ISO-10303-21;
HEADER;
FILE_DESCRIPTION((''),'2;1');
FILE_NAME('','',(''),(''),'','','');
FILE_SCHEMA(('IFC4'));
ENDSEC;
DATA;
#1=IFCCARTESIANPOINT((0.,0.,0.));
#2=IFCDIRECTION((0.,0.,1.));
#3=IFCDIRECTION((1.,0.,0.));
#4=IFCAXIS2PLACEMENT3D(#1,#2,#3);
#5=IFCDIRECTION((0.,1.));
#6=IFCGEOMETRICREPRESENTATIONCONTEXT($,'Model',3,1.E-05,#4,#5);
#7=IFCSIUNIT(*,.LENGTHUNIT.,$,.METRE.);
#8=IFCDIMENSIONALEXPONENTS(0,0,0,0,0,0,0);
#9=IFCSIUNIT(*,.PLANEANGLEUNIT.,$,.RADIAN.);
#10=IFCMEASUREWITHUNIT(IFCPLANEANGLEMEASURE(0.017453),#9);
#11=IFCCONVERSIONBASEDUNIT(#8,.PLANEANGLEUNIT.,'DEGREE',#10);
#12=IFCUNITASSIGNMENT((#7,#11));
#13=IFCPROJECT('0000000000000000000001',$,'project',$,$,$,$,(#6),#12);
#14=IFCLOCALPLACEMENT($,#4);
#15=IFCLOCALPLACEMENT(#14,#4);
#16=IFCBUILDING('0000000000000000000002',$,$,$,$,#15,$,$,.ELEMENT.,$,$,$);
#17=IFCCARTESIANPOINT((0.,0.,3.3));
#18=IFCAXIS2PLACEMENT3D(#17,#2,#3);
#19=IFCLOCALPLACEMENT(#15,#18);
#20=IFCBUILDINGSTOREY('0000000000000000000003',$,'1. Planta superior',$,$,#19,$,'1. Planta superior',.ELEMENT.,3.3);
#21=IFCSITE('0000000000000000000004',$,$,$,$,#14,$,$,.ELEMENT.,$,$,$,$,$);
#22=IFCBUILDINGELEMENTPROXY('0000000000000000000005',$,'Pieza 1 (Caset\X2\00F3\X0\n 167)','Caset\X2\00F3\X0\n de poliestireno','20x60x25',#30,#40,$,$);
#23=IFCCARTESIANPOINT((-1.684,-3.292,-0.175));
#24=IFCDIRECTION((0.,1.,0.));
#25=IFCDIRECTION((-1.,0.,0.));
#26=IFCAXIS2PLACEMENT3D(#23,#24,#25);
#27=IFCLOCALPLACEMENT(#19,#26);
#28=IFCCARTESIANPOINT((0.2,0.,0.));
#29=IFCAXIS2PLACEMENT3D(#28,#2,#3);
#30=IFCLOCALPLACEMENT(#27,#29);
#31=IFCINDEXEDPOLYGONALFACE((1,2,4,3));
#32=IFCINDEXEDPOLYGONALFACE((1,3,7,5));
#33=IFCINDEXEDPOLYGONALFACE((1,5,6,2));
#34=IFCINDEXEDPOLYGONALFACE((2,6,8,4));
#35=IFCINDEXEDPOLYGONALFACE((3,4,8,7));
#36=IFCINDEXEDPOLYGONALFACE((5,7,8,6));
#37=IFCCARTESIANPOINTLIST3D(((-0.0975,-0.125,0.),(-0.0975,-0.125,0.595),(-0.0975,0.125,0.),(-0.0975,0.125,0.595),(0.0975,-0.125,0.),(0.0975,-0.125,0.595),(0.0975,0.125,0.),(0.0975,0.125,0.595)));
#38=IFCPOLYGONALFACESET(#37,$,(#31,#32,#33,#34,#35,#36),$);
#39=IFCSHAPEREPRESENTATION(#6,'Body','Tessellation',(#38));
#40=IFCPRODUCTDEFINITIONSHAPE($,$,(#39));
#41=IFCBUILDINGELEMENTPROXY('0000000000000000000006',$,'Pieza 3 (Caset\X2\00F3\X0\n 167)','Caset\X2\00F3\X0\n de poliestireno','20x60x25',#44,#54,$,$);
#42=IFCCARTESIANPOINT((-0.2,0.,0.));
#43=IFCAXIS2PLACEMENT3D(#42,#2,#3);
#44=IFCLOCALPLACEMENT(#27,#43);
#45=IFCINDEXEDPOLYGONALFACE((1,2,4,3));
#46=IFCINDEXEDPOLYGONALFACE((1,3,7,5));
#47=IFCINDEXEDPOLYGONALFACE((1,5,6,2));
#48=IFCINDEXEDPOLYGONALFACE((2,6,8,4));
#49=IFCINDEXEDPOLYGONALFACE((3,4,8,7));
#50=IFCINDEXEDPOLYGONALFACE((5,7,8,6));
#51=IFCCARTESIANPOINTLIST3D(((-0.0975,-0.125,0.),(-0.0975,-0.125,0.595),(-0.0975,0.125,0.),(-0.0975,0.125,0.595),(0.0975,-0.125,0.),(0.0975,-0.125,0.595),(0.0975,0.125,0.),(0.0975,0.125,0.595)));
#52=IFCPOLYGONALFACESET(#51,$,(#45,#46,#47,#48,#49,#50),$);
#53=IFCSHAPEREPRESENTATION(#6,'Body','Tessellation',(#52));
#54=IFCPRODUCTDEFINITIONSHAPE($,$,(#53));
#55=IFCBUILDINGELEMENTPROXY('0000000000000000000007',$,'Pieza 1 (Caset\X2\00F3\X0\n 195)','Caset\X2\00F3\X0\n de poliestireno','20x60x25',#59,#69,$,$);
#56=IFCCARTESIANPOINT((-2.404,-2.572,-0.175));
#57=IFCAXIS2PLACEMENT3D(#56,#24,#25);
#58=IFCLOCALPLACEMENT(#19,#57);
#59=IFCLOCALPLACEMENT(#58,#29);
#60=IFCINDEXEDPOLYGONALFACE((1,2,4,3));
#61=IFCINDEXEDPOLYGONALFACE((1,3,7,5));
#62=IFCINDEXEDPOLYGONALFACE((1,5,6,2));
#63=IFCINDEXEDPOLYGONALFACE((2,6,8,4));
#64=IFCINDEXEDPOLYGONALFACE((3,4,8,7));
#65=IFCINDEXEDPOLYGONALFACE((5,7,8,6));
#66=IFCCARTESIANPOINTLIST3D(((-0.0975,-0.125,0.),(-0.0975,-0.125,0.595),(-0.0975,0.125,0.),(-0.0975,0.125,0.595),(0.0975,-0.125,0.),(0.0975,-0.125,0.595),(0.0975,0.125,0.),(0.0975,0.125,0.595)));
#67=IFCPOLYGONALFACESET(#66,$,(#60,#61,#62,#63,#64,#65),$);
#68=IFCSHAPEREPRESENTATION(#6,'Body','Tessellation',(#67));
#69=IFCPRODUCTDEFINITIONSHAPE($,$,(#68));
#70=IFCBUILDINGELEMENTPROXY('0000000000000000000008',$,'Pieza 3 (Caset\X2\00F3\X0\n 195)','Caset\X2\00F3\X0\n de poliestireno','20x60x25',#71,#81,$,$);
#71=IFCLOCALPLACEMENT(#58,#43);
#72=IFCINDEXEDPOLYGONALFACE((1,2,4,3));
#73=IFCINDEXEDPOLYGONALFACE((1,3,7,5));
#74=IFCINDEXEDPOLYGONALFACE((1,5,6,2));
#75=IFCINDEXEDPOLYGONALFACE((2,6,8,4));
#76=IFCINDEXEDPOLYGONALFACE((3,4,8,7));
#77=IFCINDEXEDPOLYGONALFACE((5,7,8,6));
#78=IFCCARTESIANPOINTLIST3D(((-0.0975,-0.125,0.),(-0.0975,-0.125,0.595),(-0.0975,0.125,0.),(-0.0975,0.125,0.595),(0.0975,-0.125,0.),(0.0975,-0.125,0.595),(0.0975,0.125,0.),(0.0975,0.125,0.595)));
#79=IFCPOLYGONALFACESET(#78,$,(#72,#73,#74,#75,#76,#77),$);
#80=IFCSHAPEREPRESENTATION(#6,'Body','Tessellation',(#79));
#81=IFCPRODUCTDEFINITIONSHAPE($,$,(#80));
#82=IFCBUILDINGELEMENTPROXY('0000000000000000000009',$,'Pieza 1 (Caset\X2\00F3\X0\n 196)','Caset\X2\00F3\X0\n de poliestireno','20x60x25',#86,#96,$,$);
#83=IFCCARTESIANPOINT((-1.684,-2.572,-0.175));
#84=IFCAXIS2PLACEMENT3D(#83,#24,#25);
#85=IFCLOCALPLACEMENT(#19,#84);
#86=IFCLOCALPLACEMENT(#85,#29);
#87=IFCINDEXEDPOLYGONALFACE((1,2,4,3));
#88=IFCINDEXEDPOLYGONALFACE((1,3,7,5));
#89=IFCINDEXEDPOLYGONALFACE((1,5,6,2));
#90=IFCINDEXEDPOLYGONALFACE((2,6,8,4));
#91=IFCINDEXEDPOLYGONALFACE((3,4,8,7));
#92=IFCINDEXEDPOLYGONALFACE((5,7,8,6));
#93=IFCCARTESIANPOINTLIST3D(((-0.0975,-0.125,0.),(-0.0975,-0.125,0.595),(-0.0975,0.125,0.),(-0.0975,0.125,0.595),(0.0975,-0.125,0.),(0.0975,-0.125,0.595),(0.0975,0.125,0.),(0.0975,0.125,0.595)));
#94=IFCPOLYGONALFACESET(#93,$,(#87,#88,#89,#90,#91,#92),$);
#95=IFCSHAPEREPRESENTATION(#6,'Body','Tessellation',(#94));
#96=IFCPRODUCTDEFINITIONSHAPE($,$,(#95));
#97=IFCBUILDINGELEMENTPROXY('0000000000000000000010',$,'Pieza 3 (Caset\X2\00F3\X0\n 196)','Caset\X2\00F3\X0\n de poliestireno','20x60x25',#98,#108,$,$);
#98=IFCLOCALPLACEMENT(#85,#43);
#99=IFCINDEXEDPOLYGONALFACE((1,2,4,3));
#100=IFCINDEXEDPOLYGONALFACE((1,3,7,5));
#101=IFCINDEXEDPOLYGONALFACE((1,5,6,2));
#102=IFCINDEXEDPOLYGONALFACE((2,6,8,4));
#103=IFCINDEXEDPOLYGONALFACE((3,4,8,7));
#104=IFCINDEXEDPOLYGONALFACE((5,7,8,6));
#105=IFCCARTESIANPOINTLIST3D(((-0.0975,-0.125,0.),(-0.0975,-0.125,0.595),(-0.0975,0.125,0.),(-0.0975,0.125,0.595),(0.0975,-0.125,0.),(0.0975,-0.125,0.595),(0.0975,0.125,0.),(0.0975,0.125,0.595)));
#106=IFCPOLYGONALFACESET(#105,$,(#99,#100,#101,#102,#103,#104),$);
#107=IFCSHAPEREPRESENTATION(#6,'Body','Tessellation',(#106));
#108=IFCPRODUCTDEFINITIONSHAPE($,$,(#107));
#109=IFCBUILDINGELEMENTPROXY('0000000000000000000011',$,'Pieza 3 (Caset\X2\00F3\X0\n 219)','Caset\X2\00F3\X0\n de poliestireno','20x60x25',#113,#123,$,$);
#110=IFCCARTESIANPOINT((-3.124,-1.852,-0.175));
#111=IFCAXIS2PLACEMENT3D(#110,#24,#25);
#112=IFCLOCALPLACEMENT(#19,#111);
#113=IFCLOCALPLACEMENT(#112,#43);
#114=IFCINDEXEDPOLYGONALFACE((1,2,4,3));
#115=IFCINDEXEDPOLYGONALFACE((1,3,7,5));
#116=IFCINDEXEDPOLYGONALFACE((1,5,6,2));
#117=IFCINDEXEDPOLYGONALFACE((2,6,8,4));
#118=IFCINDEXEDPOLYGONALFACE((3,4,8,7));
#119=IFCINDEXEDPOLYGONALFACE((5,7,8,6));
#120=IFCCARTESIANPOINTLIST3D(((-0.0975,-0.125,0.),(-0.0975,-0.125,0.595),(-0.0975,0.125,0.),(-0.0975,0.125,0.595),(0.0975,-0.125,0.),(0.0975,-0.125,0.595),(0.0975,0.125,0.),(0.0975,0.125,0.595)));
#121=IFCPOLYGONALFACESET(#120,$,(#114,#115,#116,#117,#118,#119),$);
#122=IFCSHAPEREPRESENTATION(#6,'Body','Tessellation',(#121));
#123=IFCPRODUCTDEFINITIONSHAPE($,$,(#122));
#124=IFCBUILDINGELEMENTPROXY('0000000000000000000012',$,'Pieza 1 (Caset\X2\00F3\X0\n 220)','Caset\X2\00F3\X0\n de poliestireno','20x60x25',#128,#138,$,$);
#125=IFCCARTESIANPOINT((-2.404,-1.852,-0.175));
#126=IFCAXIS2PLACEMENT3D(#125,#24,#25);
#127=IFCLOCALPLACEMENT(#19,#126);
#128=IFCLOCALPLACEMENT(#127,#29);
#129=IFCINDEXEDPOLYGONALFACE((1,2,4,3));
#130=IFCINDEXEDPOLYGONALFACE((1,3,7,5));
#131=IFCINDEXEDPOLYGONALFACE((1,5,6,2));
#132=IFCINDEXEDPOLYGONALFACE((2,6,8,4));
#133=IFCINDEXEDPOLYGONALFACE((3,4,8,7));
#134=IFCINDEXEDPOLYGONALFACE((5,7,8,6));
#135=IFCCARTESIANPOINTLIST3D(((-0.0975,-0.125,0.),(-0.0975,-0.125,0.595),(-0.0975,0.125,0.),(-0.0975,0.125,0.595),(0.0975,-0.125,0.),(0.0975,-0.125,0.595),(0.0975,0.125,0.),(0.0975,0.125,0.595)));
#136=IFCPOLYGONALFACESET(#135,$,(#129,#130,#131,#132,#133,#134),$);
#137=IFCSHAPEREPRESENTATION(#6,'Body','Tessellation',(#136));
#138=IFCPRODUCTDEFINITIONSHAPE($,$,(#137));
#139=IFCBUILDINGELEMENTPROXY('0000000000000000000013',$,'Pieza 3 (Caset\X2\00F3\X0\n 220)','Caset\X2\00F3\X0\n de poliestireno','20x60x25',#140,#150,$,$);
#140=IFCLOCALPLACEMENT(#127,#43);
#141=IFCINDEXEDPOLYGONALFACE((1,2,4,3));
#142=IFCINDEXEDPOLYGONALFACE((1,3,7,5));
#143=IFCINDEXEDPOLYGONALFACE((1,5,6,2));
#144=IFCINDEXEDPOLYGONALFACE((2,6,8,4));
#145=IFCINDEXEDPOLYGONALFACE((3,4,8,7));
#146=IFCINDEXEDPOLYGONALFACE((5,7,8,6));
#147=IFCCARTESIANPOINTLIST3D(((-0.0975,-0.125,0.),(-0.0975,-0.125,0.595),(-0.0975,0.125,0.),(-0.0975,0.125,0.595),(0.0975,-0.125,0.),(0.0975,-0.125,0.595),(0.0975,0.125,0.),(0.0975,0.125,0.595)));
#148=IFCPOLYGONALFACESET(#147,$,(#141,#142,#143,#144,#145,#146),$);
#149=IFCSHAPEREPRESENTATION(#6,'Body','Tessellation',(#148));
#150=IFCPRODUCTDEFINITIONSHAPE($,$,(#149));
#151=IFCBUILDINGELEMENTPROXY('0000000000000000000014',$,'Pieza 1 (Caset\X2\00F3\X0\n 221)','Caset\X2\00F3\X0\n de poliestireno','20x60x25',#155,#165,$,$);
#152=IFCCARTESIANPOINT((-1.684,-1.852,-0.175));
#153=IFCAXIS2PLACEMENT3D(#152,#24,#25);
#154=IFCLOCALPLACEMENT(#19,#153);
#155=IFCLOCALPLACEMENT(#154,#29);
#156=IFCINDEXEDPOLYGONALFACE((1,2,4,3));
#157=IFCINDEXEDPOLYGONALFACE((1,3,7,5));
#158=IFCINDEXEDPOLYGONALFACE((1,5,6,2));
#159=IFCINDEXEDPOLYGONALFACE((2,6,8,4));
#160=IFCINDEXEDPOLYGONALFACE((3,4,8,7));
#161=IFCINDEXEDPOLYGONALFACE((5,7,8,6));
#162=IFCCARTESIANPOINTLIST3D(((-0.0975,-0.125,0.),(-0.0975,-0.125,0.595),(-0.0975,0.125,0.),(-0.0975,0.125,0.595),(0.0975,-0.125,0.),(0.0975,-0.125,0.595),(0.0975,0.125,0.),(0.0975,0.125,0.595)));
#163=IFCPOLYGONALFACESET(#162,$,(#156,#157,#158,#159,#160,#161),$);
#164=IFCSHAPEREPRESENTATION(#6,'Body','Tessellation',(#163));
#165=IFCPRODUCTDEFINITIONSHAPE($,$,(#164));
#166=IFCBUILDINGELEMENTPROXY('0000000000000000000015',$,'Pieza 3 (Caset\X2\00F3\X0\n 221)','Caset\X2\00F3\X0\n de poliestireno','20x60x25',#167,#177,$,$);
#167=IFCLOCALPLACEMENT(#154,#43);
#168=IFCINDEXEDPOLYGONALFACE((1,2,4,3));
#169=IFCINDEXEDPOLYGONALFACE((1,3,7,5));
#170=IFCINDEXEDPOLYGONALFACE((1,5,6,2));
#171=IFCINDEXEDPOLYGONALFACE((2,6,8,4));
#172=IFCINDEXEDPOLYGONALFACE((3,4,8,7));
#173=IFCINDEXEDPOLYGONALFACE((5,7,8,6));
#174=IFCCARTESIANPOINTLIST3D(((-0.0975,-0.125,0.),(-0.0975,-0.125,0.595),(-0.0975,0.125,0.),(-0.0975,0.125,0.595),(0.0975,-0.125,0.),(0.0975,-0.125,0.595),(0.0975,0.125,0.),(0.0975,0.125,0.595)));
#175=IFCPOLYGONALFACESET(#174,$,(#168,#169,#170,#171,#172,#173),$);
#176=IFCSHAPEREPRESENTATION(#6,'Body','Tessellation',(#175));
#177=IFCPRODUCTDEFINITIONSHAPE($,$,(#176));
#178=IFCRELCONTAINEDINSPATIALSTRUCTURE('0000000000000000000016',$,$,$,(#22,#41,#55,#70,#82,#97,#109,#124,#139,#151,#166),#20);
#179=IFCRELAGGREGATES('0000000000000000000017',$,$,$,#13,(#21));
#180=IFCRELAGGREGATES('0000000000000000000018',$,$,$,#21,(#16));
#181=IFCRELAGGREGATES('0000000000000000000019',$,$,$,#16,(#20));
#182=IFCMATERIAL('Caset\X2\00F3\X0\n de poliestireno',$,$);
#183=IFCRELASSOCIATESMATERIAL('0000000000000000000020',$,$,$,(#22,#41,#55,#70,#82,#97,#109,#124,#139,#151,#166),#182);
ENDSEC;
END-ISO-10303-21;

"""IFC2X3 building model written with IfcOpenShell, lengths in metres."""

from ifc_helpers import new_model, entity, si_unit, converted_unit, direction, frame, origin_with_axes, origin_2d_with_axis, place, context, project, spatial, rectangle, extrude, source, transform, mapped, material, element, save


model = new_model("IFC2X3")

# Units and contexts
model_context = context("Model", 3, precision=1e-05, world=origin_with_axes(), true_north=direction((0.0, 1.0)))
ifc_project = project(units=[si_unit("LENGTHUNIT", "METRE"), converted_unit("PLANEANGLEUNIT", "DEGREE", entity("IfcPlaneAngleMeasure", 0.017453), si_unit("PLANEANGLEUNIT", "RADIAN"), dimensions=[0, 0, 0, 0, 0, 0, 0])], contexts=[model_context])

# Site, building, storey
site_placement = place(None, origin_with_axes())
site = spatial("IfcSite", under=ifc_project, at=site_placement, CompositionType="ELEMENT")
building_placement = place(site_placement, origin_with_axes())
building = spatial("IfcBuilding", under=site, at=building_placement, CompositionType="ELEMENT")
storey_placement = place(building_placement, frame((0.0, 0.0, 3.3), z_axis=(0.0, 0.0, 1.0), x_axis=(1.0, 0.0, 0.0)))
storey = spatial("IfcBuildingStorey", under=building, at=storey_placement, Name="1. Planta superior", LongName="1. Planta superior", CompositionType="ELEMENT", Elevation=3.3)

# Building element proxies
ifc_material = material(Name="Casetón de poliestireno")
shared_shape = source(origin_with_axes(), model_context, "Body", "SweptSolid", [
    extrude(rectangle(XDim=0.195, YDim=0.25, at=origin_2d_with_axis()), origin_with_axes(), (0.0, 0.0, 1.0), 0.595),
])
placement_1 = place(storey_placement, frame((-1.684, -3.292, -0.175), z_axis=(0.0, 1.0, 0.0), x_axis=(-1.0, 0.0, 0.0)))
for number, where, z_axis, x_axis, name in (
    (1, (0.2, 0.0, 0.0), (0.0, 0.0, 1.0), (1.0, 0.0, 0.0), "Pieza 1 (Casetón 167)"),
    (2, (-0.2, 0.0, 0.0), (0.0, 0.0, 1.0), (1.0, 0.0, 0.0), "Pieza 3 (Casetón 167)"),
):
    element("IfcBuildingElementProxy", number, at=place(placement_1, frame(where, z_axis=z_axis, x_axis=x_axis)), inside=storey, material=ifc_material, Name=name, Description="Casetón de poliestireno", ObjectType="20x60x25", context=model_context, shape_type="MappedRepresentation", body=[
        mapped(shared_shape, transform((0.0, 0.0, 0.0), x_axis=(1.0, 0.0, 0.0), y_axis=(0.0, 1.0, 0.0), z_axis=(0.0, 0.0, 1.0))),
    ])
placement_2 = place(storey_placement, frame((-2.404, -2.572, -0.175), z_axis=(0.0, 1.0, 0.0), x_axis=(-1.0, 0.0, 0.0)))
for number, where, z_axis, x_axis, name in (
    (3, (0.2, 0.0, 0.0), (0.0, 0.0, 1.0), (1.0, 0.0, 0.0), "Pieza 1 (Casetón 195)"),
    (4, (-0.2, 0.0, 0.0), (0.0, 0.0, 1.0), (1.0, 0.0, 0.0), "Pieza 3 (Casetón 195)"),
):
    element("IfcBuildingElementProxy", number, at=place(placement_2, frame(where, z_axis=z_axis, x_axis=x_axis)), inside=storey, material=ifc_material, Name=name, Description="Casetón de poliestireno", ObjectType="20x60x25", context=model_context, shape_type="MappedRepresentation", body=[
        mapped(shared_shape, transform((0.0, 0.0, 0.0), x_axis=(1.0, 0.0, 0.0), y_axis=(0.0, 1.0, 0.0), z_axis=(0.0, 0.0, 1.0))),
    ])
placement_3 = place(storey_placement, frame((-1.684, -2.572, -0.175), z_axis=(0.0, 1.0, 0.0), x_axis=(-1.0, 0.0, 0.0)))
for number, where, z_axis, x_axis, name in (
    (5, (0.2, 0.0, 0.0), (0.0, 0.0, 1.0), (1.0, 0.0, 0.0), "Pieza 1 (Casetón 196)"),
    (6, (-0.2, 0.0, 0.0), (0.0, 0.0, 1.0), (1.0, 0.0, 0.0), "Pieza 3 (Casetón 196)"),
):
    element("IfcBuildingElementProxy", number, at=place(placement_3, frame(where, z_axis=z_axis, x_axis=x_axis)), inside=storey, material=ifc_material, Name=name, Description="Casetón de poliestireno", ObjectType="20x60x25", context=model_context, shape_type="MappedRepresentation", body=[
        mapped(shared_shape, transform((0.0, 0.0, 0.0), x_axis=(1.0, 0.0, 0.0), y_axis=(0.0, 1.0, 0.0), z_axis=(0.0, 0.0, 1.0))),
    ])
placement_4 = place(storey_placement, frame((-3.124, -1.852, -0.175), z_axis=(0.0, 1.0, 0.0), x_axis=(-1.0, 0.0, 0.0)))
for number, where, z_axis, x_axis, name in (
    (7, (-0.2, 0.0, 0.0), (0.0, 0.0, 1.0), (1.0, 0.0, 0.0), "Pieza 3 (Casetón 219)"),
):
    element("IfcBuildingElementProxy", number, at=place(placement_4, frame(where, z_axis=z_axis, x_axis=x_axis)), inside=storey, material=ifc_material, Name=name, Description="Casetón de poliestireno", ObjectType="20x60x25", context=model_context, shape_type="MappedRepresentation", body=[
        mapped(shared_shape, transform((0.0, 0.0, 0.0), x_axis=(1.0, 0.0, 0.0), y_axis=(0.0, 1.0, 0.0), z_axis=(0.0, 0.0, 1.0))),
    ])
placement_5 = place(storey_placement, frame((-2.404, -1.852, -0.175), z_axis=(0.0, 1.0, 0.0), x_axis=(-1.0, 0.0, 0.0)))
for number, where, z_axis, x_axis, name in (
    (8, (0.2, 0.0, 0.0), (0.0, 0.0, 1.0), (1.0, 0.0, 0.0), "Pieza 1 (Casetón 220)"),
    (9, (-0.2, 0.0, 0.0), (0.0, 0.0, 1.0), (1.0, 0.0, 0.0), "Pieza 3 (Casetón 220)"),
):
    element("IfcBuildingElementProxy", number, at=place(placement_5, frame(where, z_axis=z_axis, x_axis=x_axis)), inside=storey, material=ifc_material, Name=name, Description="Casetón de poliestireno", ObjectType="20x60x25", context=model_context, shape_type="MappedRepresentation", body=[
        mapped(shared_shape, transform((0.0, 0.0, 0.0), x_axis=(1.0, 0.0, 0.0), y_axis=(0.0, 1.0, 0.0), z_axis=(0.0, 0.0, 1.0))),
    ])
placement_6 = place(storey_placement, frame((-1.684, -1.852, -0.175), z_axis=(0.0, 1.0, 0.0), x_axis=(-1.0, 0.0, 0.0)))
for number, where, z_axis, x_axis, name in (
    (10, (0.2, 0.0, 0.0), (0.0, 0.0, 1.0), (1.0, 0.0, 0.0), "Pieza 1 (Casetón 221)"),
    (11, (-0.2, 0.0, 0.0), (0.0, 0.0, 1.0), (1.0, 0.0, 0.0), "Pieza 3 (Casetón 221)"),
):
    element("IfcBuildingElementProxy", number, at=place(placement_6, frame(where, z_axis=z_axis, x_axis=x_axis)), inside=storey, material=ifc_material, Name=name, Description="Casetón de poliestireno", ObjectType="20x60x25", context=model_context, shape_type="MappedRepresentation", body=[
        mapped(shared_shape, transform((0.0, 0.0, 0.0), x_axis=(1.0, 0.0, 0.0), y_axis=(0.0, 1.0, 0.0), z_axis=(0.0, 0.0, 1.0))),
    ])

save(model, "model.ifc")
